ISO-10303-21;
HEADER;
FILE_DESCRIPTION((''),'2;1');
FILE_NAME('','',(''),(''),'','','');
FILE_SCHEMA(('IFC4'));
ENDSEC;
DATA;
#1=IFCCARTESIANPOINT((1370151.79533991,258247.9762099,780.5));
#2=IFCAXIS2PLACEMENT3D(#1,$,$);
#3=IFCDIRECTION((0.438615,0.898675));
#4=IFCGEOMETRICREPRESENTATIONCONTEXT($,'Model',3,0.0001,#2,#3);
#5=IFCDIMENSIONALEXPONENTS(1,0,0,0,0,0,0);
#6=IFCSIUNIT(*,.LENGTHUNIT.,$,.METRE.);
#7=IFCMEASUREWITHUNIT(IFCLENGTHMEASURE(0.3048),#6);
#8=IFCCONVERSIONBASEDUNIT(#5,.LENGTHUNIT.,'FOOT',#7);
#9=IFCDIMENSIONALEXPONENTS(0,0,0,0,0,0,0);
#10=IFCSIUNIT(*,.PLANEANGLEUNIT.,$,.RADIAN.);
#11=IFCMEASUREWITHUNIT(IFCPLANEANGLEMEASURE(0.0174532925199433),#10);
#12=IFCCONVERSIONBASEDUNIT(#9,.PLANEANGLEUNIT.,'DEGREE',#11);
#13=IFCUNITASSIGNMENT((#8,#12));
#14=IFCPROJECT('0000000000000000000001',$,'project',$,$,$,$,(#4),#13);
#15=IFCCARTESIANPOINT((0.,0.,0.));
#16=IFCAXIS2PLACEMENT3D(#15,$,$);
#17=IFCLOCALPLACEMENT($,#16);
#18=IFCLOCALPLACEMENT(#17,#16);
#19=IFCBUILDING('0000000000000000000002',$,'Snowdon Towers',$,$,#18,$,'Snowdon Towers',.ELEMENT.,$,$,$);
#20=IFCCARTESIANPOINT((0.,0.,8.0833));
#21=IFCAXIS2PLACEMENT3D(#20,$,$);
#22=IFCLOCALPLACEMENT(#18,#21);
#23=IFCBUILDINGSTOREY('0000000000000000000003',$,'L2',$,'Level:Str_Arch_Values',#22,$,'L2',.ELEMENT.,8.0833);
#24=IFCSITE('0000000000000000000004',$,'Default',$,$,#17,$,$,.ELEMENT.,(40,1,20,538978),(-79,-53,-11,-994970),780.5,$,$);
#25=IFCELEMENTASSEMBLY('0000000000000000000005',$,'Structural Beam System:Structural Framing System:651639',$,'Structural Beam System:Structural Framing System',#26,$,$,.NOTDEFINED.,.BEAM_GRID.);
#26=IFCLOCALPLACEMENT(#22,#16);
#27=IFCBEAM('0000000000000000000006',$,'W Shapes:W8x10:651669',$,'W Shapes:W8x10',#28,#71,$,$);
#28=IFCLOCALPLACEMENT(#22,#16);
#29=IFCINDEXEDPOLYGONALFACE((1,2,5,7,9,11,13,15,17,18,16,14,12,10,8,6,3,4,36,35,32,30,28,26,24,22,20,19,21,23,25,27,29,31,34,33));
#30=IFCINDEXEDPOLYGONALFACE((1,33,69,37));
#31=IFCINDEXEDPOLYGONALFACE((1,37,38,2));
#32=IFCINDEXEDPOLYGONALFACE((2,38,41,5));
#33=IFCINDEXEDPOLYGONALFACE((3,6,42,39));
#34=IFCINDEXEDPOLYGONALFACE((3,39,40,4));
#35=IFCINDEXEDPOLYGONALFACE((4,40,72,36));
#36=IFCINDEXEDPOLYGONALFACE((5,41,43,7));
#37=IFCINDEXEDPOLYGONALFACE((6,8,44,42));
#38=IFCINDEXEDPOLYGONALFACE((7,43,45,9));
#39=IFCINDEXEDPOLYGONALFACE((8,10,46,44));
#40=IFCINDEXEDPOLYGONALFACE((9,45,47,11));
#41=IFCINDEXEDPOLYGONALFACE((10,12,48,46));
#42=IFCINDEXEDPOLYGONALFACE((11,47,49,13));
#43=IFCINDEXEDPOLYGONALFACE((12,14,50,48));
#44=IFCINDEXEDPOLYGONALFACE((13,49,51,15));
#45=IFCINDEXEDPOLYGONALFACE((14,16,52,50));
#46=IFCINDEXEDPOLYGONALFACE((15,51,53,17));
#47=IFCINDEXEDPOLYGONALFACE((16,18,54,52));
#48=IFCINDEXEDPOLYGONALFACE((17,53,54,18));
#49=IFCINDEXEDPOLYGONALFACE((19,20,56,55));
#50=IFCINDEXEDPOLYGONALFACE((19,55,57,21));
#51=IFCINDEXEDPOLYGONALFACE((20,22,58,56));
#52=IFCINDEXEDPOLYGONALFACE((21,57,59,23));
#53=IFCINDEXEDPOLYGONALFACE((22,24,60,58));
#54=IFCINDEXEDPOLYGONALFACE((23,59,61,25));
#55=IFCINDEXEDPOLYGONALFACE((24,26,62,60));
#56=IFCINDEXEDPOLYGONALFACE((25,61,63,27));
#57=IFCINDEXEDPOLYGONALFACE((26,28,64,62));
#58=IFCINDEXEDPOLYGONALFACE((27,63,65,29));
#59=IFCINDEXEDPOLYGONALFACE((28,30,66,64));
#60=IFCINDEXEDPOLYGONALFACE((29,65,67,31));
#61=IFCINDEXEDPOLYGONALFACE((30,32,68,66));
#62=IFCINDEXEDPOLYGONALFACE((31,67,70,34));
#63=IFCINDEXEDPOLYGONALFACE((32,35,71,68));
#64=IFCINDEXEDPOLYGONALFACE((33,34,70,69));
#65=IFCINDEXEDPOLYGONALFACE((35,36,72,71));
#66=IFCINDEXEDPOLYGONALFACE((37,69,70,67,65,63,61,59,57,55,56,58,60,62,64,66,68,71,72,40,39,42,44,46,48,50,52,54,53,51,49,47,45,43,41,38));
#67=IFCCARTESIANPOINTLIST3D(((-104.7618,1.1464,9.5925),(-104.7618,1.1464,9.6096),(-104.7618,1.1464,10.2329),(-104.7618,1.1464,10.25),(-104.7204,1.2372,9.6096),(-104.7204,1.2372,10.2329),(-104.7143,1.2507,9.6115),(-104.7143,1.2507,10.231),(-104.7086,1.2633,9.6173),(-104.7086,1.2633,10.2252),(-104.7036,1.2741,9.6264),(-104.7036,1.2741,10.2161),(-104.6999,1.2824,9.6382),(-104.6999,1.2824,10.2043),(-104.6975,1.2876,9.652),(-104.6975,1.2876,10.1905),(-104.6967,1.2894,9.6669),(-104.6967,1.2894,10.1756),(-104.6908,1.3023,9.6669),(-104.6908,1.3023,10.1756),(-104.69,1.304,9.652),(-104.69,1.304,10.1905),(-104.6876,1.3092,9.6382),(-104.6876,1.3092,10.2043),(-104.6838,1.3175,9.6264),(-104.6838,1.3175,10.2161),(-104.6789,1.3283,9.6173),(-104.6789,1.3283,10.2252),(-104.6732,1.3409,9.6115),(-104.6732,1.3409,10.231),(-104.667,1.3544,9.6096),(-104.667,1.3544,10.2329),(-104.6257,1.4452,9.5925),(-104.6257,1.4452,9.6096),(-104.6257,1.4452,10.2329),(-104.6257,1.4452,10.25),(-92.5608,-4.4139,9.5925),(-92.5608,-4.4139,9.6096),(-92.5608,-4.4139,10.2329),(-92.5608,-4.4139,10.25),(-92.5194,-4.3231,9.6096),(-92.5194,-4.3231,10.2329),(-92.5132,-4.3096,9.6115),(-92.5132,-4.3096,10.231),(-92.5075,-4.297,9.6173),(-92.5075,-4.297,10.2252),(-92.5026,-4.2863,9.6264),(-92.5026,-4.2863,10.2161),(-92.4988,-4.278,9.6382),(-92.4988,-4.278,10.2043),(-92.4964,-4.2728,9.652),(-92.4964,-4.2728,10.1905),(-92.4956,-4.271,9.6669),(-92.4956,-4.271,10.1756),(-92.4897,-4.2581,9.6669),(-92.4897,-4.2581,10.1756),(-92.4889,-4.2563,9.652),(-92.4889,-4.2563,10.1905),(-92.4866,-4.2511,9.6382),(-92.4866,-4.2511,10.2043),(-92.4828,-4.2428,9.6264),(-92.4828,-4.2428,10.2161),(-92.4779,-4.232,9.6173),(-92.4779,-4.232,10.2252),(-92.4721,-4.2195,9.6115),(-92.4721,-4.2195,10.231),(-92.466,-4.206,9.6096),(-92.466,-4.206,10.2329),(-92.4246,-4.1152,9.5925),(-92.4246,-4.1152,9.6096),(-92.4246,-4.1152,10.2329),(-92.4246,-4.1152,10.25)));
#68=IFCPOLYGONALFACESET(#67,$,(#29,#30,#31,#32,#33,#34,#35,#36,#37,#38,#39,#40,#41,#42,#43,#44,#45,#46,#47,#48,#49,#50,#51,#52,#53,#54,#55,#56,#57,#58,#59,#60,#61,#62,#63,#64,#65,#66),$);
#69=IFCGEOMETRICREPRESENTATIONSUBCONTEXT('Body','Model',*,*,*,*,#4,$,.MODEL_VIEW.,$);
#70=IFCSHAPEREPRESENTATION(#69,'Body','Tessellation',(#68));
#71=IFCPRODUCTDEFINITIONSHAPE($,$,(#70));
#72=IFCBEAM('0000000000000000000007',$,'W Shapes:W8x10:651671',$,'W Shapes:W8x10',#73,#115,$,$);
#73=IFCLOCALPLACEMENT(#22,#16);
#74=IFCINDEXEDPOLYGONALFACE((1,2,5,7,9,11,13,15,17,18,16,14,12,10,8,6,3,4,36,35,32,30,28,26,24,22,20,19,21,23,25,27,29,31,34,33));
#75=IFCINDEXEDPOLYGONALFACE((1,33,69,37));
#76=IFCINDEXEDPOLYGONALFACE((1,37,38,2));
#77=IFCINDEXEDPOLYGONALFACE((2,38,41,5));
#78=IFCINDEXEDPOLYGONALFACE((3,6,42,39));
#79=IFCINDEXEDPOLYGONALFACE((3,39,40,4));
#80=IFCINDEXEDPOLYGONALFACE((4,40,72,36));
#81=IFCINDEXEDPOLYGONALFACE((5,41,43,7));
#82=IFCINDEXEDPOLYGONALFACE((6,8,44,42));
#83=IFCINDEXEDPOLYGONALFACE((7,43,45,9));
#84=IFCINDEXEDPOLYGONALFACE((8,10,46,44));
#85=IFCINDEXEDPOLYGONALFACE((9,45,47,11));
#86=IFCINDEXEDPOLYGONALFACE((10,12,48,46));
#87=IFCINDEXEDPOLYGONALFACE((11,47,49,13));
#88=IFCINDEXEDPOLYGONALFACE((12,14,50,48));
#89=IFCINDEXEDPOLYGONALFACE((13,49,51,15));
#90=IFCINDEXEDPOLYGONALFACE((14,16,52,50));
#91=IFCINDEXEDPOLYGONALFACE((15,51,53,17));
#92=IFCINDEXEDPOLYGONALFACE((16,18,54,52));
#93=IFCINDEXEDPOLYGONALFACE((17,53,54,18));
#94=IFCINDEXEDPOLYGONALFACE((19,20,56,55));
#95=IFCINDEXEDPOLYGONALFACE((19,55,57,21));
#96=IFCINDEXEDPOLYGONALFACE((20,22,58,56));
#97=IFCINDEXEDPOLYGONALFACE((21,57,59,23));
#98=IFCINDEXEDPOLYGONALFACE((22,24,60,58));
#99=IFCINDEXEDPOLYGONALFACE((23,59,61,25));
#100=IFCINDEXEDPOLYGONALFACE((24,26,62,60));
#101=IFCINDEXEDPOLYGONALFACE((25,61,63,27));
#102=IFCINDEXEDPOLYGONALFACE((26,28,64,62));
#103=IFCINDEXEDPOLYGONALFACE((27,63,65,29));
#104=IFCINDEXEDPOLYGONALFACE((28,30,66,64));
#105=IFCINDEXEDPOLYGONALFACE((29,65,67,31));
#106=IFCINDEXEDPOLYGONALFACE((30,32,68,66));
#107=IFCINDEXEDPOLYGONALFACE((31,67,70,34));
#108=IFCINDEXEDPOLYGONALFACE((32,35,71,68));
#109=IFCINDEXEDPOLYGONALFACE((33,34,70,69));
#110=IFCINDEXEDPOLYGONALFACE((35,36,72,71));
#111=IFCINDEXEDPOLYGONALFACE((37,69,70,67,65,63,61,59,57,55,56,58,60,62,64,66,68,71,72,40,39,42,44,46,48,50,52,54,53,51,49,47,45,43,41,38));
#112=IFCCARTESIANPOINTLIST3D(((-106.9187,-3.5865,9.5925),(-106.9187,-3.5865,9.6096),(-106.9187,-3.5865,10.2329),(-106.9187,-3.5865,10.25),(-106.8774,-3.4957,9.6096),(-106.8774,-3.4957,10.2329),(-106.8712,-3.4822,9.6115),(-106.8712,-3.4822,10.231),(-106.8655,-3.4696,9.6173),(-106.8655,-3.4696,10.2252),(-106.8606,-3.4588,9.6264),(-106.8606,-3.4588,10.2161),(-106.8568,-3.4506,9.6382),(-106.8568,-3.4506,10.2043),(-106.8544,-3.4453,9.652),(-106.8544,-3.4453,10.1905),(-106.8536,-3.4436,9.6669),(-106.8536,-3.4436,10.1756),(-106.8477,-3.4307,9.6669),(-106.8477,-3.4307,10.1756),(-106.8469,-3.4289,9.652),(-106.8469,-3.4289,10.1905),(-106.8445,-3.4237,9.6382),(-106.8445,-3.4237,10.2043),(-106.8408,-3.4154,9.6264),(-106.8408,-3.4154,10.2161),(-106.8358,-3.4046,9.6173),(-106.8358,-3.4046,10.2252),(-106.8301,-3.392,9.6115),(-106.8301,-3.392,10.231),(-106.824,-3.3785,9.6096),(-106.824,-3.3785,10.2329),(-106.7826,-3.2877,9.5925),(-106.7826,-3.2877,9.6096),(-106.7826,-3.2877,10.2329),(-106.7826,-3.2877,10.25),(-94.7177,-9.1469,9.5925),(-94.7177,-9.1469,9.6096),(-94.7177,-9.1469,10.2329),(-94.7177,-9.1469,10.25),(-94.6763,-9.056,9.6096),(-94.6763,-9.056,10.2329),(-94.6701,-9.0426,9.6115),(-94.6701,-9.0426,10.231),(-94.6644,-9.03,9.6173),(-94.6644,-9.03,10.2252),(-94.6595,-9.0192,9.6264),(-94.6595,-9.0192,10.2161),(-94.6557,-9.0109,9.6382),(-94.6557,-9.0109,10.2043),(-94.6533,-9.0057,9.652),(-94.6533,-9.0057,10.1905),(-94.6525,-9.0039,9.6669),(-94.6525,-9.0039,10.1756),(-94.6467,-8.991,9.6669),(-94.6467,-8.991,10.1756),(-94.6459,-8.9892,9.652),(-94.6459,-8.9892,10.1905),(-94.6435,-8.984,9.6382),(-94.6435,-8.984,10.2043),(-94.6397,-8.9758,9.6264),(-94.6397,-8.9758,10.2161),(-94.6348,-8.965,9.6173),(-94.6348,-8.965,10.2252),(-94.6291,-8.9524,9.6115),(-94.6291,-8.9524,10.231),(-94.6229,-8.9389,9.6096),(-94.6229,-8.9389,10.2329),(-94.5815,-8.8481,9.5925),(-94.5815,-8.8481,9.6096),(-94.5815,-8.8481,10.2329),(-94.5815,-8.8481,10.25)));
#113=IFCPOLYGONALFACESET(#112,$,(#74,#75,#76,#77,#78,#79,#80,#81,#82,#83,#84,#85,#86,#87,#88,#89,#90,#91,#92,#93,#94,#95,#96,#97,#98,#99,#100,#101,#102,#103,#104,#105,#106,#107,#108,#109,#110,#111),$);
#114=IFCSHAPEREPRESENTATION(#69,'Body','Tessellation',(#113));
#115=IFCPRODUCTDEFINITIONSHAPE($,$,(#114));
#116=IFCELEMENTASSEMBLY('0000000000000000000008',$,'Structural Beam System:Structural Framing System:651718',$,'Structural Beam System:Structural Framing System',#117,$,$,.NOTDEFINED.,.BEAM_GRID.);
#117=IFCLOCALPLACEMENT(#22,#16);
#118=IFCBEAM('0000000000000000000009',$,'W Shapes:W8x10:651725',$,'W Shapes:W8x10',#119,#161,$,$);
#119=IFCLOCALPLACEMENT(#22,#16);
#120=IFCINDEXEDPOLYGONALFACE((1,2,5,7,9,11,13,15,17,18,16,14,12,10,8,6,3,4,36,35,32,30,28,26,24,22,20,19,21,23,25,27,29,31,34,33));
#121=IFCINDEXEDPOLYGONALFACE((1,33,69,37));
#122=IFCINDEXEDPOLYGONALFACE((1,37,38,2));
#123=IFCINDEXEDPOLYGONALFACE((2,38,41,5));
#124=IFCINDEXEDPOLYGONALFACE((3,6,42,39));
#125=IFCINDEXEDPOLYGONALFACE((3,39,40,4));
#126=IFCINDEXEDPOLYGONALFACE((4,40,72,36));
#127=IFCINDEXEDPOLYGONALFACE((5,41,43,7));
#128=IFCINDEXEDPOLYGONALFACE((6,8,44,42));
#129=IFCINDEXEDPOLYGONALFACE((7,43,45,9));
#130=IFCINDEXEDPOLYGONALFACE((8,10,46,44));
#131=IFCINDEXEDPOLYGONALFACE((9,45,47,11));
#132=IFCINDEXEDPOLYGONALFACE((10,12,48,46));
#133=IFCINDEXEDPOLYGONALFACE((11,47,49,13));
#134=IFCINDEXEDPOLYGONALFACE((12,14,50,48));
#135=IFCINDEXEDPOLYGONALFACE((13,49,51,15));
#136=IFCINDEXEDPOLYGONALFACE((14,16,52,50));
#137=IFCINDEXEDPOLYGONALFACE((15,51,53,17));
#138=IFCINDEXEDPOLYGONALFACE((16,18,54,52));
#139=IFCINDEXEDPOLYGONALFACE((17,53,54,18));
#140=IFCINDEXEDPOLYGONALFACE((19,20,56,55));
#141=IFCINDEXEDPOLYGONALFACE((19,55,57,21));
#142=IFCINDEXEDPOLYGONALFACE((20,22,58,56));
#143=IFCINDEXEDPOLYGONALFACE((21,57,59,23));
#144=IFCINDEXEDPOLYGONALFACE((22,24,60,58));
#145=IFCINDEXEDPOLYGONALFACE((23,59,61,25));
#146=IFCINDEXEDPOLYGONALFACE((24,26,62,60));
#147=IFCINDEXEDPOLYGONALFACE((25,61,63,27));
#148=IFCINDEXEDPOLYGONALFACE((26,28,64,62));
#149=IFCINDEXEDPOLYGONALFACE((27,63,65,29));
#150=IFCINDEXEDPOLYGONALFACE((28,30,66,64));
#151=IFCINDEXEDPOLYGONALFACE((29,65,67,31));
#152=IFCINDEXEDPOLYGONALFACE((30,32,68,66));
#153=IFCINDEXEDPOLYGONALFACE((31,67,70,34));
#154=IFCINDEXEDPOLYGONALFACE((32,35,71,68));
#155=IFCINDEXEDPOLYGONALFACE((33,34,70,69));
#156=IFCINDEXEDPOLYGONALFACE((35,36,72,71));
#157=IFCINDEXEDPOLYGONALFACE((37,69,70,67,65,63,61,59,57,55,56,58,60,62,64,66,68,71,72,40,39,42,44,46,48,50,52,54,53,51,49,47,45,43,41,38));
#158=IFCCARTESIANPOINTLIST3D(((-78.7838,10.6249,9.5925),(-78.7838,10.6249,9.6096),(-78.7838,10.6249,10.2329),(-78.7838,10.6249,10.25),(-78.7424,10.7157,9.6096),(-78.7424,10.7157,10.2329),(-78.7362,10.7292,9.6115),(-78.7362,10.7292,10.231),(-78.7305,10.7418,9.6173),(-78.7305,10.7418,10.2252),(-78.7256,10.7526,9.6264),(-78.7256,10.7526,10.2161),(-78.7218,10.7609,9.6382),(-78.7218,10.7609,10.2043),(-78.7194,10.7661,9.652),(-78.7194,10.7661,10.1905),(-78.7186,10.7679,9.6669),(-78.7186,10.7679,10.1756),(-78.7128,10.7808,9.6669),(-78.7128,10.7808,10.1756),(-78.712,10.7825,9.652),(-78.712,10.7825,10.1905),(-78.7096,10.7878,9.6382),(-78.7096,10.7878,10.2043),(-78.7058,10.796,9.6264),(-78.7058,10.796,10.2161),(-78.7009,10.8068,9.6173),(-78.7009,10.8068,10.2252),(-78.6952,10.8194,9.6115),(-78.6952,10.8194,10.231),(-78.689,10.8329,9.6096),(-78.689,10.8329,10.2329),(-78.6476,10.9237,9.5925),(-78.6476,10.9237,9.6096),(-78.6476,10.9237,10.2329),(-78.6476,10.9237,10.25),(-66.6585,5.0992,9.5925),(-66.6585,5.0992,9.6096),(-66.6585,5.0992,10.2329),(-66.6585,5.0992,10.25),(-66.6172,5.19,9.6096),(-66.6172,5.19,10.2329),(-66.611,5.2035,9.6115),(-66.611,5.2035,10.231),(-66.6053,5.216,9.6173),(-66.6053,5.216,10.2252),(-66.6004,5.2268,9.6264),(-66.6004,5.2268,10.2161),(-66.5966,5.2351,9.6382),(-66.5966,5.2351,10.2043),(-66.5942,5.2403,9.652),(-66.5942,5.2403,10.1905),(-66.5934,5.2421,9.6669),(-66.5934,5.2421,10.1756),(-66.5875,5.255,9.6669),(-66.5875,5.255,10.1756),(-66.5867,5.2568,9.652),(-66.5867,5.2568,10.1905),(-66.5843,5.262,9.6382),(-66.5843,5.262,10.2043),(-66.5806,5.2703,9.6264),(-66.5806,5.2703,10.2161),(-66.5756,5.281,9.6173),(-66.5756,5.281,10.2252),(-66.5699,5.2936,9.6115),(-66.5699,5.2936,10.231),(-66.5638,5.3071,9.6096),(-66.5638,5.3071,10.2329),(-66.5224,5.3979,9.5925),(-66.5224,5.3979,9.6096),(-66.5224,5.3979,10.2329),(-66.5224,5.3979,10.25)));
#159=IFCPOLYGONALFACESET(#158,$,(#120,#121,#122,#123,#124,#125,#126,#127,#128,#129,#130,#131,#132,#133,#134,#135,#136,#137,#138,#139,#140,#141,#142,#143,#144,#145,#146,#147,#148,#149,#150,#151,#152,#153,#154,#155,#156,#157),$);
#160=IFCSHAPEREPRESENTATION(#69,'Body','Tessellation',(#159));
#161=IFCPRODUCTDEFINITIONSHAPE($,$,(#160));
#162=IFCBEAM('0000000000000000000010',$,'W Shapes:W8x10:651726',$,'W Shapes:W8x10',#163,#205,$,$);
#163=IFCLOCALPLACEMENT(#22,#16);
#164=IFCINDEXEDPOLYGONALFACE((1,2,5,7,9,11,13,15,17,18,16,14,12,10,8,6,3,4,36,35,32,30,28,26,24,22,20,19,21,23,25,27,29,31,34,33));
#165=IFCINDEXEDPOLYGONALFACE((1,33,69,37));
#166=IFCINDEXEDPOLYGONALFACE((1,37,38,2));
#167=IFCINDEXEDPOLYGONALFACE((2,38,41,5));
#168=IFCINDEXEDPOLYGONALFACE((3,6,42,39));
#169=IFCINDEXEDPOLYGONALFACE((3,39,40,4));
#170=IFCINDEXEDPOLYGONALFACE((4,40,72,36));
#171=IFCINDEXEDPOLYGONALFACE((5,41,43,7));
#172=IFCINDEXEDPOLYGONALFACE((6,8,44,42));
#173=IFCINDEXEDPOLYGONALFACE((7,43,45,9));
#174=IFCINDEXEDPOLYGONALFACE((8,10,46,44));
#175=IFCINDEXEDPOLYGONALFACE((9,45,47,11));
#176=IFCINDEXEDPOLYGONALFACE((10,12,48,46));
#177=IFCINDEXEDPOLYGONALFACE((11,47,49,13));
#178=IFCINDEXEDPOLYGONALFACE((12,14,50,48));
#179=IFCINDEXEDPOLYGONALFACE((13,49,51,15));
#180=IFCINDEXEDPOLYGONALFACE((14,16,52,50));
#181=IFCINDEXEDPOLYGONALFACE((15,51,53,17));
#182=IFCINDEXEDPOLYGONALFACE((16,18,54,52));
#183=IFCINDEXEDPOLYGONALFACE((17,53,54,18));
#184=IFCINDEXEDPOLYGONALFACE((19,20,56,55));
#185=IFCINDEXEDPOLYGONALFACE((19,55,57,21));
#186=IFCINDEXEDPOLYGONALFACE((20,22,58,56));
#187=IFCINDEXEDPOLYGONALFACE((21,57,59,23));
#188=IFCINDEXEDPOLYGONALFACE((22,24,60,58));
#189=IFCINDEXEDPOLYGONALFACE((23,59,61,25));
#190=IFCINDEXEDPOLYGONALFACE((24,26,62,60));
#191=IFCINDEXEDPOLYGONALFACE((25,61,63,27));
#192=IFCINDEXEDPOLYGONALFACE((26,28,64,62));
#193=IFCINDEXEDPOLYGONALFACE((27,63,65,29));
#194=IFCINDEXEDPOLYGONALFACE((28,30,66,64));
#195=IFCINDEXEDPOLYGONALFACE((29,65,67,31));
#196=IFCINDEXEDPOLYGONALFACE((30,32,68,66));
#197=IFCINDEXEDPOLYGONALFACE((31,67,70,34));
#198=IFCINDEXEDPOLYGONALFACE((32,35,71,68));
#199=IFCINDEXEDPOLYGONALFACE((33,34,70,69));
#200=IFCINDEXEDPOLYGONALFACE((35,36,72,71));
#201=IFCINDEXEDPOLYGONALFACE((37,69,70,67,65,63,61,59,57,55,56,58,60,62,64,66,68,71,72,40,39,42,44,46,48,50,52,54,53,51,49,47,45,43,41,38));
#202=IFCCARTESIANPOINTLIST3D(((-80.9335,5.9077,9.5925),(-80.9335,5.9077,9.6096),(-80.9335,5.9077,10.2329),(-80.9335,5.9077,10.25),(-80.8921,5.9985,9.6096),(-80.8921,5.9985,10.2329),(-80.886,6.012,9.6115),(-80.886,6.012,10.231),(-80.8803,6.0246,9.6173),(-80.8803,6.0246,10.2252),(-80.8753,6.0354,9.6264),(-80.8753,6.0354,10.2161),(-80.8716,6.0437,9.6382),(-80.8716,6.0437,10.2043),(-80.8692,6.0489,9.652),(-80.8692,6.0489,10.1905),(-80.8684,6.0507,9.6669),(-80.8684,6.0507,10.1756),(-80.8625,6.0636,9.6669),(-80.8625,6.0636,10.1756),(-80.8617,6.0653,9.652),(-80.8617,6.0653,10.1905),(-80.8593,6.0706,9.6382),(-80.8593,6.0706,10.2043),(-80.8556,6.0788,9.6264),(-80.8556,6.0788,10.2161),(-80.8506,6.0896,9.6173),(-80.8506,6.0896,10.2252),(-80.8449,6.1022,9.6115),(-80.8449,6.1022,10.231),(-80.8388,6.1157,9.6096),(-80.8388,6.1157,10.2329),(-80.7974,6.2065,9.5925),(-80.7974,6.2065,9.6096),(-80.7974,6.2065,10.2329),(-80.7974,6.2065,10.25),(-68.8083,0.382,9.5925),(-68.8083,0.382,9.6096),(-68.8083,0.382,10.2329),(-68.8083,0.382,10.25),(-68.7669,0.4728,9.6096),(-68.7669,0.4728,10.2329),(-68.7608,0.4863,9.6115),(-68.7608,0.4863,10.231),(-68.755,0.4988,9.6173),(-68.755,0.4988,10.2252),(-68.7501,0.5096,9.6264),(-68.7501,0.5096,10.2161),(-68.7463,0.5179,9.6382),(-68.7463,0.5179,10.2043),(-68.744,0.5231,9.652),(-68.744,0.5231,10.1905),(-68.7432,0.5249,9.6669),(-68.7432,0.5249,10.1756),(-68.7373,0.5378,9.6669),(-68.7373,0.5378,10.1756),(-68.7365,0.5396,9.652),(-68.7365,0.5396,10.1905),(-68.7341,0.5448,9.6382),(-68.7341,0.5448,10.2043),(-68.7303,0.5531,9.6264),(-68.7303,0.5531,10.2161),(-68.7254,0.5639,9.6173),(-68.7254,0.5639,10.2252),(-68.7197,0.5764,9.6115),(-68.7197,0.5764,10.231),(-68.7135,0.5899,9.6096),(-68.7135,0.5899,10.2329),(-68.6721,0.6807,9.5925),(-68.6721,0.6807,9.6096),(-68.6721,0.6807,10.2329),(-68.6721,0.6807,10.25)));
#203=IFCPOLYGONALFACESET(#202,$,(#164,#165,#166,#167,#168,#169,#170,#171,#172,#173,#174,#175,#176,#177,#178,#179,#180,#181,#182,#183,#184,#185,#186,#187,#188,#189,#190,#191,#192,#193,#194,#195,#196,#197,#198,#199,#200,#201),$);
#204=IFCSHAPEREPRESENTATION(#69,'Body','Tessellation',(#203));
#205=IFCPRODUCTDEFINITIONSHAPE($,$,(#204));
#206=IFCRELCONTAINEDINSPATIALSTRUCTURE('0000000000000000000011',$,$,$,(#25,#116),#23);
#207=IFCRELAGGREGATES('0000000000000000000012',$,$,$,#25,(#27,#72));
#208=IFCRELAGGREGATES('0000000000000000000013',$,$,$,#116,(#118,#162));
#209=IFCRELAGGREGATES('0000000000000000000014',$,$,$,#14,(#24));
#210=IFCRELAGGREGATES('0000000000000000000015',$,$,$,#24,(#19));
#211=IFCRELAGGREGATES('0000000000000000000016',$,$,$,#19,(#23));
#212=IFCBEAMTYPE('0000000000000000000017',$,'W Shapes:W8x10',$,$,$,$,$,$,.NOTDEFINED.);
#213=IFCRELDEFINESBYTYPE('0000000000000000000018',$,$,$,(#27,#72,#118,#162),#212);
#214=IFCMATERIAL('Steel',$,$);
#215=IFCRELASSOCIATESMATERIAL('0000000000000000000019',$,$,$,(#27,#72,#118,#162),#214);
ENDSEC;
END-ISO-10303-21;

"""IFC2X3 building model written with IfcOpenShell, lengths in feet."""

from ifc_helpers import new_model, entity, si_unit, converted_unit, direction, frame, frame_2d, origin, place, context, subcontext, project, spatial, i_section, extrude, material, type_object, element, aggregate, save


model = new_model("IFC2X3")

# Units and contexts
model_context = context("Model", 3, precision=0.0001, world=frame((1370151.79533991, 258247.9762099, 780.5)), true_north=direction((0.438615, 0.898675)))
body_context = subcontext(model_context, "Body", "Model", "MODEL_VIEW")
ifc_project = project(units=[converted_unit("LENGTHUNIT", "FOOT", entity("IfcLengthMeasure", 0.3048), si_unit("LENGTHUNIT", "METRE"), dimensions=[1, 0, 0, 0, 0, 0, 0]), converted_unit("PLANEANGLEUNIT", "DEGREE", entity("IfcPlaneAngleMeasure", 0.0174532925199433), si_unit("PLANEANGLEUNIT", "RADIAN"), dimensions=[0, 0, 0, 0, 0, 0, 0])], contexts=[model_context])

# Site, building, storey
site_placement = place(None, origin())
site = spatial("IfcSite", under=ifc_project, at=site_placement, Name="Default", CompositionType="ELEMENT", RefLatitude=(40, 1, 20, 538978), RefLongitude=(-79, -53, -11, -994970), RefElevation=780.5)
building_placement = place(site_placement, origin())
building = spatial("IfcBuilding", under=site, at=building_placement, Name="Snowdon Towers", LongName="Snowdon Towers", CompositionType="ELEMENT")
storey_placement = place(building_placement, frame((0.0, 0.0, 8.0833)))
storey = spatial("IfcBuildingStorey", under=building, at=storey_placement, Name="L2", ObjectType="Level:Str_Arch_Values", LongName="L2", CompositionType="ELEMENT", Elevation=8.0833)

# Shared definitions
ifc_material_1 = material(Name="Steel")

# Element assemblies, beams
assembly_1_placement = place(storey_placement, origin())
assembly_1 = element("IfcElementAssembly", 1, at=assembly_1_placement, inside=storey, Name="Structural Beam System:Structural Framing System:651639", ObjectType="Structural Beam System:Structural Framing System", AssemblyPlace="NOTDEFINED", PredefinedType="BEAM_GRID")
beam_type_1 = type_object("IfcBeamType", Name="W Shapes:W8x10", PredefinedType="NOTDEFINED")
beam_1_placement = place(assembly_1_placement, frame((-105.1146, 1.4876, 10.25), z_axis=(0.0, 0.0, 1.0), x_axis=(0.909961, -0.414693, 0.0)))
beam_1 = element("IfcBeam", 2, at=beam_1_placement, type_object=beam_type_1, material=ifc_material_1, Name="W Shapes:W8x10:651669", ObjectType="W Shapes:W8x10", context=body_context, shape_type="SweptSolid", body=[
    extrude(i_section(OverallWidth=0.3283, OverallDepth=0.6575, WebThickness=0.0142, FlangeThickness=0.0171, FilletRadius=0.0573, at=frame_2d((0.0, 0.0), x_axis=(0.0, 1.0))), frame((0.4625, 0.0, -0.3288), z_axis=(1.0, 0.0, 0.0), x_axis=(0.0, 0.0, -1.0)), (0.0, 0.0, 1.0), 13.4083),
])
beam_2_placement = place(assembly_1_placement, frame((-107.2715, -3.2453, 10.25), z_axis=(0.0, 0.0, 1.0), x_axis=(0.909961, -0.414693, 0.0)))
beam_2 = element("IfcBeam", 3, at=beam_2_placement, type_object=beam_type_1, material=ifc_material_1, Name="W Shapes:W8x10:651671", ObjectType="W Shapes:W8x10", context=body_context, shape_type="SweptSolid", body=[
    extrude(i_section(OverallWidth=0.3283, OverallDepth=0.6575, WebThickness=0.0142, FlangeThickness=0.0171, FilletRadius=0.0573, at=frame_2d((0.0, 0.0), x_axis=(0.0, 1.0))), frame((0.4625, 0.0, -0.3288), z_axis=(1.0, 0.0, 0.0), x_axis=(0.0, 0.0, -1.0)), (0.0, 0.0, 1.0), 13.4083),
])
aggregate(assembly_1, [beam_1, beam_2])
assembly_2_placement = place(storey_placement, origin())
assembly_2 = element("IfcElementAssembly", 4, at=assembly_2_placement, inside=storey, Name="Structural Beam System:Structural Framing System:651718", ObjectType="Structural Beam System:Structural Framing System", AssemblyPlace="NOTDEFINED", PredefinedType="BEAM_GRID")
beam_3_placement = place(assembly_2_placement, frame((-79.1366, 10.9661, 10.25), z_axis=(0.0, 0.0, 1.0), x_axis=(0.909961, -0.414693, 0.0)))
beam_3 = element("IfcBeam", 5, at=beam_3_placement, type_object=beam_type_1, material=ifc_material_1, Name="W Shapes:W8x10:651725", ObjectType="W Shapes:W8x10", context=body_context, shape_type="SweptSolid", body=[
    extrude(i_section(OverallWidth=0.3283, OverallDepth=0.6575, WebThickness=0.0142, FlangeThickness=0.0171, FilletRadius=0.0573, at=frame_2d((0.0, 0.0), x_axis=(0.0, 1.0))), frame((0.4625, 0.0, -0.3288), z_axis=(1.0, 0.0, 0.0), x_axis=(0.0, 0.0, -1.0)), (0.0, 0.0, 1.0), 13.325),
])
beam_4_placement = place(assembly_2_placement, frame((-81.2863, 6.2489, 10.25), z_axis=(0.0, 0.0, 1.0), x_axis=(0.909961, -0.414693, 0.0)))
beam_4 = element("IfcBeam", 6, at=beam_4_placement, type_object=beam_type_1, material=ifc_material_1, Name="W Shapes:W8x10:651726", ObjectType="W Shapes:W8x10", context=body_context, shape_type="SweptSolid", body=[
    extrude(i_section(OverallWidth=0.3283, OverallDepth=0.6575, WebThickness=0.0142, FlangeThickness=0.0171, FilletRadius=0.0573, at=frame_2d((0.0, 0.0), x_axis=(0.0, 1.0))), frame((0.4625, 0.0, -0.3288), z_axis=(1.0, 0.0, 0.0), x_axis=(0.0, 0.0, -1.0)), (0.0, 0.0, 1.0), 13.325),
])
aggregate(assembly_2, [beam_3, beam_4])

save(model, "model.ifc")
